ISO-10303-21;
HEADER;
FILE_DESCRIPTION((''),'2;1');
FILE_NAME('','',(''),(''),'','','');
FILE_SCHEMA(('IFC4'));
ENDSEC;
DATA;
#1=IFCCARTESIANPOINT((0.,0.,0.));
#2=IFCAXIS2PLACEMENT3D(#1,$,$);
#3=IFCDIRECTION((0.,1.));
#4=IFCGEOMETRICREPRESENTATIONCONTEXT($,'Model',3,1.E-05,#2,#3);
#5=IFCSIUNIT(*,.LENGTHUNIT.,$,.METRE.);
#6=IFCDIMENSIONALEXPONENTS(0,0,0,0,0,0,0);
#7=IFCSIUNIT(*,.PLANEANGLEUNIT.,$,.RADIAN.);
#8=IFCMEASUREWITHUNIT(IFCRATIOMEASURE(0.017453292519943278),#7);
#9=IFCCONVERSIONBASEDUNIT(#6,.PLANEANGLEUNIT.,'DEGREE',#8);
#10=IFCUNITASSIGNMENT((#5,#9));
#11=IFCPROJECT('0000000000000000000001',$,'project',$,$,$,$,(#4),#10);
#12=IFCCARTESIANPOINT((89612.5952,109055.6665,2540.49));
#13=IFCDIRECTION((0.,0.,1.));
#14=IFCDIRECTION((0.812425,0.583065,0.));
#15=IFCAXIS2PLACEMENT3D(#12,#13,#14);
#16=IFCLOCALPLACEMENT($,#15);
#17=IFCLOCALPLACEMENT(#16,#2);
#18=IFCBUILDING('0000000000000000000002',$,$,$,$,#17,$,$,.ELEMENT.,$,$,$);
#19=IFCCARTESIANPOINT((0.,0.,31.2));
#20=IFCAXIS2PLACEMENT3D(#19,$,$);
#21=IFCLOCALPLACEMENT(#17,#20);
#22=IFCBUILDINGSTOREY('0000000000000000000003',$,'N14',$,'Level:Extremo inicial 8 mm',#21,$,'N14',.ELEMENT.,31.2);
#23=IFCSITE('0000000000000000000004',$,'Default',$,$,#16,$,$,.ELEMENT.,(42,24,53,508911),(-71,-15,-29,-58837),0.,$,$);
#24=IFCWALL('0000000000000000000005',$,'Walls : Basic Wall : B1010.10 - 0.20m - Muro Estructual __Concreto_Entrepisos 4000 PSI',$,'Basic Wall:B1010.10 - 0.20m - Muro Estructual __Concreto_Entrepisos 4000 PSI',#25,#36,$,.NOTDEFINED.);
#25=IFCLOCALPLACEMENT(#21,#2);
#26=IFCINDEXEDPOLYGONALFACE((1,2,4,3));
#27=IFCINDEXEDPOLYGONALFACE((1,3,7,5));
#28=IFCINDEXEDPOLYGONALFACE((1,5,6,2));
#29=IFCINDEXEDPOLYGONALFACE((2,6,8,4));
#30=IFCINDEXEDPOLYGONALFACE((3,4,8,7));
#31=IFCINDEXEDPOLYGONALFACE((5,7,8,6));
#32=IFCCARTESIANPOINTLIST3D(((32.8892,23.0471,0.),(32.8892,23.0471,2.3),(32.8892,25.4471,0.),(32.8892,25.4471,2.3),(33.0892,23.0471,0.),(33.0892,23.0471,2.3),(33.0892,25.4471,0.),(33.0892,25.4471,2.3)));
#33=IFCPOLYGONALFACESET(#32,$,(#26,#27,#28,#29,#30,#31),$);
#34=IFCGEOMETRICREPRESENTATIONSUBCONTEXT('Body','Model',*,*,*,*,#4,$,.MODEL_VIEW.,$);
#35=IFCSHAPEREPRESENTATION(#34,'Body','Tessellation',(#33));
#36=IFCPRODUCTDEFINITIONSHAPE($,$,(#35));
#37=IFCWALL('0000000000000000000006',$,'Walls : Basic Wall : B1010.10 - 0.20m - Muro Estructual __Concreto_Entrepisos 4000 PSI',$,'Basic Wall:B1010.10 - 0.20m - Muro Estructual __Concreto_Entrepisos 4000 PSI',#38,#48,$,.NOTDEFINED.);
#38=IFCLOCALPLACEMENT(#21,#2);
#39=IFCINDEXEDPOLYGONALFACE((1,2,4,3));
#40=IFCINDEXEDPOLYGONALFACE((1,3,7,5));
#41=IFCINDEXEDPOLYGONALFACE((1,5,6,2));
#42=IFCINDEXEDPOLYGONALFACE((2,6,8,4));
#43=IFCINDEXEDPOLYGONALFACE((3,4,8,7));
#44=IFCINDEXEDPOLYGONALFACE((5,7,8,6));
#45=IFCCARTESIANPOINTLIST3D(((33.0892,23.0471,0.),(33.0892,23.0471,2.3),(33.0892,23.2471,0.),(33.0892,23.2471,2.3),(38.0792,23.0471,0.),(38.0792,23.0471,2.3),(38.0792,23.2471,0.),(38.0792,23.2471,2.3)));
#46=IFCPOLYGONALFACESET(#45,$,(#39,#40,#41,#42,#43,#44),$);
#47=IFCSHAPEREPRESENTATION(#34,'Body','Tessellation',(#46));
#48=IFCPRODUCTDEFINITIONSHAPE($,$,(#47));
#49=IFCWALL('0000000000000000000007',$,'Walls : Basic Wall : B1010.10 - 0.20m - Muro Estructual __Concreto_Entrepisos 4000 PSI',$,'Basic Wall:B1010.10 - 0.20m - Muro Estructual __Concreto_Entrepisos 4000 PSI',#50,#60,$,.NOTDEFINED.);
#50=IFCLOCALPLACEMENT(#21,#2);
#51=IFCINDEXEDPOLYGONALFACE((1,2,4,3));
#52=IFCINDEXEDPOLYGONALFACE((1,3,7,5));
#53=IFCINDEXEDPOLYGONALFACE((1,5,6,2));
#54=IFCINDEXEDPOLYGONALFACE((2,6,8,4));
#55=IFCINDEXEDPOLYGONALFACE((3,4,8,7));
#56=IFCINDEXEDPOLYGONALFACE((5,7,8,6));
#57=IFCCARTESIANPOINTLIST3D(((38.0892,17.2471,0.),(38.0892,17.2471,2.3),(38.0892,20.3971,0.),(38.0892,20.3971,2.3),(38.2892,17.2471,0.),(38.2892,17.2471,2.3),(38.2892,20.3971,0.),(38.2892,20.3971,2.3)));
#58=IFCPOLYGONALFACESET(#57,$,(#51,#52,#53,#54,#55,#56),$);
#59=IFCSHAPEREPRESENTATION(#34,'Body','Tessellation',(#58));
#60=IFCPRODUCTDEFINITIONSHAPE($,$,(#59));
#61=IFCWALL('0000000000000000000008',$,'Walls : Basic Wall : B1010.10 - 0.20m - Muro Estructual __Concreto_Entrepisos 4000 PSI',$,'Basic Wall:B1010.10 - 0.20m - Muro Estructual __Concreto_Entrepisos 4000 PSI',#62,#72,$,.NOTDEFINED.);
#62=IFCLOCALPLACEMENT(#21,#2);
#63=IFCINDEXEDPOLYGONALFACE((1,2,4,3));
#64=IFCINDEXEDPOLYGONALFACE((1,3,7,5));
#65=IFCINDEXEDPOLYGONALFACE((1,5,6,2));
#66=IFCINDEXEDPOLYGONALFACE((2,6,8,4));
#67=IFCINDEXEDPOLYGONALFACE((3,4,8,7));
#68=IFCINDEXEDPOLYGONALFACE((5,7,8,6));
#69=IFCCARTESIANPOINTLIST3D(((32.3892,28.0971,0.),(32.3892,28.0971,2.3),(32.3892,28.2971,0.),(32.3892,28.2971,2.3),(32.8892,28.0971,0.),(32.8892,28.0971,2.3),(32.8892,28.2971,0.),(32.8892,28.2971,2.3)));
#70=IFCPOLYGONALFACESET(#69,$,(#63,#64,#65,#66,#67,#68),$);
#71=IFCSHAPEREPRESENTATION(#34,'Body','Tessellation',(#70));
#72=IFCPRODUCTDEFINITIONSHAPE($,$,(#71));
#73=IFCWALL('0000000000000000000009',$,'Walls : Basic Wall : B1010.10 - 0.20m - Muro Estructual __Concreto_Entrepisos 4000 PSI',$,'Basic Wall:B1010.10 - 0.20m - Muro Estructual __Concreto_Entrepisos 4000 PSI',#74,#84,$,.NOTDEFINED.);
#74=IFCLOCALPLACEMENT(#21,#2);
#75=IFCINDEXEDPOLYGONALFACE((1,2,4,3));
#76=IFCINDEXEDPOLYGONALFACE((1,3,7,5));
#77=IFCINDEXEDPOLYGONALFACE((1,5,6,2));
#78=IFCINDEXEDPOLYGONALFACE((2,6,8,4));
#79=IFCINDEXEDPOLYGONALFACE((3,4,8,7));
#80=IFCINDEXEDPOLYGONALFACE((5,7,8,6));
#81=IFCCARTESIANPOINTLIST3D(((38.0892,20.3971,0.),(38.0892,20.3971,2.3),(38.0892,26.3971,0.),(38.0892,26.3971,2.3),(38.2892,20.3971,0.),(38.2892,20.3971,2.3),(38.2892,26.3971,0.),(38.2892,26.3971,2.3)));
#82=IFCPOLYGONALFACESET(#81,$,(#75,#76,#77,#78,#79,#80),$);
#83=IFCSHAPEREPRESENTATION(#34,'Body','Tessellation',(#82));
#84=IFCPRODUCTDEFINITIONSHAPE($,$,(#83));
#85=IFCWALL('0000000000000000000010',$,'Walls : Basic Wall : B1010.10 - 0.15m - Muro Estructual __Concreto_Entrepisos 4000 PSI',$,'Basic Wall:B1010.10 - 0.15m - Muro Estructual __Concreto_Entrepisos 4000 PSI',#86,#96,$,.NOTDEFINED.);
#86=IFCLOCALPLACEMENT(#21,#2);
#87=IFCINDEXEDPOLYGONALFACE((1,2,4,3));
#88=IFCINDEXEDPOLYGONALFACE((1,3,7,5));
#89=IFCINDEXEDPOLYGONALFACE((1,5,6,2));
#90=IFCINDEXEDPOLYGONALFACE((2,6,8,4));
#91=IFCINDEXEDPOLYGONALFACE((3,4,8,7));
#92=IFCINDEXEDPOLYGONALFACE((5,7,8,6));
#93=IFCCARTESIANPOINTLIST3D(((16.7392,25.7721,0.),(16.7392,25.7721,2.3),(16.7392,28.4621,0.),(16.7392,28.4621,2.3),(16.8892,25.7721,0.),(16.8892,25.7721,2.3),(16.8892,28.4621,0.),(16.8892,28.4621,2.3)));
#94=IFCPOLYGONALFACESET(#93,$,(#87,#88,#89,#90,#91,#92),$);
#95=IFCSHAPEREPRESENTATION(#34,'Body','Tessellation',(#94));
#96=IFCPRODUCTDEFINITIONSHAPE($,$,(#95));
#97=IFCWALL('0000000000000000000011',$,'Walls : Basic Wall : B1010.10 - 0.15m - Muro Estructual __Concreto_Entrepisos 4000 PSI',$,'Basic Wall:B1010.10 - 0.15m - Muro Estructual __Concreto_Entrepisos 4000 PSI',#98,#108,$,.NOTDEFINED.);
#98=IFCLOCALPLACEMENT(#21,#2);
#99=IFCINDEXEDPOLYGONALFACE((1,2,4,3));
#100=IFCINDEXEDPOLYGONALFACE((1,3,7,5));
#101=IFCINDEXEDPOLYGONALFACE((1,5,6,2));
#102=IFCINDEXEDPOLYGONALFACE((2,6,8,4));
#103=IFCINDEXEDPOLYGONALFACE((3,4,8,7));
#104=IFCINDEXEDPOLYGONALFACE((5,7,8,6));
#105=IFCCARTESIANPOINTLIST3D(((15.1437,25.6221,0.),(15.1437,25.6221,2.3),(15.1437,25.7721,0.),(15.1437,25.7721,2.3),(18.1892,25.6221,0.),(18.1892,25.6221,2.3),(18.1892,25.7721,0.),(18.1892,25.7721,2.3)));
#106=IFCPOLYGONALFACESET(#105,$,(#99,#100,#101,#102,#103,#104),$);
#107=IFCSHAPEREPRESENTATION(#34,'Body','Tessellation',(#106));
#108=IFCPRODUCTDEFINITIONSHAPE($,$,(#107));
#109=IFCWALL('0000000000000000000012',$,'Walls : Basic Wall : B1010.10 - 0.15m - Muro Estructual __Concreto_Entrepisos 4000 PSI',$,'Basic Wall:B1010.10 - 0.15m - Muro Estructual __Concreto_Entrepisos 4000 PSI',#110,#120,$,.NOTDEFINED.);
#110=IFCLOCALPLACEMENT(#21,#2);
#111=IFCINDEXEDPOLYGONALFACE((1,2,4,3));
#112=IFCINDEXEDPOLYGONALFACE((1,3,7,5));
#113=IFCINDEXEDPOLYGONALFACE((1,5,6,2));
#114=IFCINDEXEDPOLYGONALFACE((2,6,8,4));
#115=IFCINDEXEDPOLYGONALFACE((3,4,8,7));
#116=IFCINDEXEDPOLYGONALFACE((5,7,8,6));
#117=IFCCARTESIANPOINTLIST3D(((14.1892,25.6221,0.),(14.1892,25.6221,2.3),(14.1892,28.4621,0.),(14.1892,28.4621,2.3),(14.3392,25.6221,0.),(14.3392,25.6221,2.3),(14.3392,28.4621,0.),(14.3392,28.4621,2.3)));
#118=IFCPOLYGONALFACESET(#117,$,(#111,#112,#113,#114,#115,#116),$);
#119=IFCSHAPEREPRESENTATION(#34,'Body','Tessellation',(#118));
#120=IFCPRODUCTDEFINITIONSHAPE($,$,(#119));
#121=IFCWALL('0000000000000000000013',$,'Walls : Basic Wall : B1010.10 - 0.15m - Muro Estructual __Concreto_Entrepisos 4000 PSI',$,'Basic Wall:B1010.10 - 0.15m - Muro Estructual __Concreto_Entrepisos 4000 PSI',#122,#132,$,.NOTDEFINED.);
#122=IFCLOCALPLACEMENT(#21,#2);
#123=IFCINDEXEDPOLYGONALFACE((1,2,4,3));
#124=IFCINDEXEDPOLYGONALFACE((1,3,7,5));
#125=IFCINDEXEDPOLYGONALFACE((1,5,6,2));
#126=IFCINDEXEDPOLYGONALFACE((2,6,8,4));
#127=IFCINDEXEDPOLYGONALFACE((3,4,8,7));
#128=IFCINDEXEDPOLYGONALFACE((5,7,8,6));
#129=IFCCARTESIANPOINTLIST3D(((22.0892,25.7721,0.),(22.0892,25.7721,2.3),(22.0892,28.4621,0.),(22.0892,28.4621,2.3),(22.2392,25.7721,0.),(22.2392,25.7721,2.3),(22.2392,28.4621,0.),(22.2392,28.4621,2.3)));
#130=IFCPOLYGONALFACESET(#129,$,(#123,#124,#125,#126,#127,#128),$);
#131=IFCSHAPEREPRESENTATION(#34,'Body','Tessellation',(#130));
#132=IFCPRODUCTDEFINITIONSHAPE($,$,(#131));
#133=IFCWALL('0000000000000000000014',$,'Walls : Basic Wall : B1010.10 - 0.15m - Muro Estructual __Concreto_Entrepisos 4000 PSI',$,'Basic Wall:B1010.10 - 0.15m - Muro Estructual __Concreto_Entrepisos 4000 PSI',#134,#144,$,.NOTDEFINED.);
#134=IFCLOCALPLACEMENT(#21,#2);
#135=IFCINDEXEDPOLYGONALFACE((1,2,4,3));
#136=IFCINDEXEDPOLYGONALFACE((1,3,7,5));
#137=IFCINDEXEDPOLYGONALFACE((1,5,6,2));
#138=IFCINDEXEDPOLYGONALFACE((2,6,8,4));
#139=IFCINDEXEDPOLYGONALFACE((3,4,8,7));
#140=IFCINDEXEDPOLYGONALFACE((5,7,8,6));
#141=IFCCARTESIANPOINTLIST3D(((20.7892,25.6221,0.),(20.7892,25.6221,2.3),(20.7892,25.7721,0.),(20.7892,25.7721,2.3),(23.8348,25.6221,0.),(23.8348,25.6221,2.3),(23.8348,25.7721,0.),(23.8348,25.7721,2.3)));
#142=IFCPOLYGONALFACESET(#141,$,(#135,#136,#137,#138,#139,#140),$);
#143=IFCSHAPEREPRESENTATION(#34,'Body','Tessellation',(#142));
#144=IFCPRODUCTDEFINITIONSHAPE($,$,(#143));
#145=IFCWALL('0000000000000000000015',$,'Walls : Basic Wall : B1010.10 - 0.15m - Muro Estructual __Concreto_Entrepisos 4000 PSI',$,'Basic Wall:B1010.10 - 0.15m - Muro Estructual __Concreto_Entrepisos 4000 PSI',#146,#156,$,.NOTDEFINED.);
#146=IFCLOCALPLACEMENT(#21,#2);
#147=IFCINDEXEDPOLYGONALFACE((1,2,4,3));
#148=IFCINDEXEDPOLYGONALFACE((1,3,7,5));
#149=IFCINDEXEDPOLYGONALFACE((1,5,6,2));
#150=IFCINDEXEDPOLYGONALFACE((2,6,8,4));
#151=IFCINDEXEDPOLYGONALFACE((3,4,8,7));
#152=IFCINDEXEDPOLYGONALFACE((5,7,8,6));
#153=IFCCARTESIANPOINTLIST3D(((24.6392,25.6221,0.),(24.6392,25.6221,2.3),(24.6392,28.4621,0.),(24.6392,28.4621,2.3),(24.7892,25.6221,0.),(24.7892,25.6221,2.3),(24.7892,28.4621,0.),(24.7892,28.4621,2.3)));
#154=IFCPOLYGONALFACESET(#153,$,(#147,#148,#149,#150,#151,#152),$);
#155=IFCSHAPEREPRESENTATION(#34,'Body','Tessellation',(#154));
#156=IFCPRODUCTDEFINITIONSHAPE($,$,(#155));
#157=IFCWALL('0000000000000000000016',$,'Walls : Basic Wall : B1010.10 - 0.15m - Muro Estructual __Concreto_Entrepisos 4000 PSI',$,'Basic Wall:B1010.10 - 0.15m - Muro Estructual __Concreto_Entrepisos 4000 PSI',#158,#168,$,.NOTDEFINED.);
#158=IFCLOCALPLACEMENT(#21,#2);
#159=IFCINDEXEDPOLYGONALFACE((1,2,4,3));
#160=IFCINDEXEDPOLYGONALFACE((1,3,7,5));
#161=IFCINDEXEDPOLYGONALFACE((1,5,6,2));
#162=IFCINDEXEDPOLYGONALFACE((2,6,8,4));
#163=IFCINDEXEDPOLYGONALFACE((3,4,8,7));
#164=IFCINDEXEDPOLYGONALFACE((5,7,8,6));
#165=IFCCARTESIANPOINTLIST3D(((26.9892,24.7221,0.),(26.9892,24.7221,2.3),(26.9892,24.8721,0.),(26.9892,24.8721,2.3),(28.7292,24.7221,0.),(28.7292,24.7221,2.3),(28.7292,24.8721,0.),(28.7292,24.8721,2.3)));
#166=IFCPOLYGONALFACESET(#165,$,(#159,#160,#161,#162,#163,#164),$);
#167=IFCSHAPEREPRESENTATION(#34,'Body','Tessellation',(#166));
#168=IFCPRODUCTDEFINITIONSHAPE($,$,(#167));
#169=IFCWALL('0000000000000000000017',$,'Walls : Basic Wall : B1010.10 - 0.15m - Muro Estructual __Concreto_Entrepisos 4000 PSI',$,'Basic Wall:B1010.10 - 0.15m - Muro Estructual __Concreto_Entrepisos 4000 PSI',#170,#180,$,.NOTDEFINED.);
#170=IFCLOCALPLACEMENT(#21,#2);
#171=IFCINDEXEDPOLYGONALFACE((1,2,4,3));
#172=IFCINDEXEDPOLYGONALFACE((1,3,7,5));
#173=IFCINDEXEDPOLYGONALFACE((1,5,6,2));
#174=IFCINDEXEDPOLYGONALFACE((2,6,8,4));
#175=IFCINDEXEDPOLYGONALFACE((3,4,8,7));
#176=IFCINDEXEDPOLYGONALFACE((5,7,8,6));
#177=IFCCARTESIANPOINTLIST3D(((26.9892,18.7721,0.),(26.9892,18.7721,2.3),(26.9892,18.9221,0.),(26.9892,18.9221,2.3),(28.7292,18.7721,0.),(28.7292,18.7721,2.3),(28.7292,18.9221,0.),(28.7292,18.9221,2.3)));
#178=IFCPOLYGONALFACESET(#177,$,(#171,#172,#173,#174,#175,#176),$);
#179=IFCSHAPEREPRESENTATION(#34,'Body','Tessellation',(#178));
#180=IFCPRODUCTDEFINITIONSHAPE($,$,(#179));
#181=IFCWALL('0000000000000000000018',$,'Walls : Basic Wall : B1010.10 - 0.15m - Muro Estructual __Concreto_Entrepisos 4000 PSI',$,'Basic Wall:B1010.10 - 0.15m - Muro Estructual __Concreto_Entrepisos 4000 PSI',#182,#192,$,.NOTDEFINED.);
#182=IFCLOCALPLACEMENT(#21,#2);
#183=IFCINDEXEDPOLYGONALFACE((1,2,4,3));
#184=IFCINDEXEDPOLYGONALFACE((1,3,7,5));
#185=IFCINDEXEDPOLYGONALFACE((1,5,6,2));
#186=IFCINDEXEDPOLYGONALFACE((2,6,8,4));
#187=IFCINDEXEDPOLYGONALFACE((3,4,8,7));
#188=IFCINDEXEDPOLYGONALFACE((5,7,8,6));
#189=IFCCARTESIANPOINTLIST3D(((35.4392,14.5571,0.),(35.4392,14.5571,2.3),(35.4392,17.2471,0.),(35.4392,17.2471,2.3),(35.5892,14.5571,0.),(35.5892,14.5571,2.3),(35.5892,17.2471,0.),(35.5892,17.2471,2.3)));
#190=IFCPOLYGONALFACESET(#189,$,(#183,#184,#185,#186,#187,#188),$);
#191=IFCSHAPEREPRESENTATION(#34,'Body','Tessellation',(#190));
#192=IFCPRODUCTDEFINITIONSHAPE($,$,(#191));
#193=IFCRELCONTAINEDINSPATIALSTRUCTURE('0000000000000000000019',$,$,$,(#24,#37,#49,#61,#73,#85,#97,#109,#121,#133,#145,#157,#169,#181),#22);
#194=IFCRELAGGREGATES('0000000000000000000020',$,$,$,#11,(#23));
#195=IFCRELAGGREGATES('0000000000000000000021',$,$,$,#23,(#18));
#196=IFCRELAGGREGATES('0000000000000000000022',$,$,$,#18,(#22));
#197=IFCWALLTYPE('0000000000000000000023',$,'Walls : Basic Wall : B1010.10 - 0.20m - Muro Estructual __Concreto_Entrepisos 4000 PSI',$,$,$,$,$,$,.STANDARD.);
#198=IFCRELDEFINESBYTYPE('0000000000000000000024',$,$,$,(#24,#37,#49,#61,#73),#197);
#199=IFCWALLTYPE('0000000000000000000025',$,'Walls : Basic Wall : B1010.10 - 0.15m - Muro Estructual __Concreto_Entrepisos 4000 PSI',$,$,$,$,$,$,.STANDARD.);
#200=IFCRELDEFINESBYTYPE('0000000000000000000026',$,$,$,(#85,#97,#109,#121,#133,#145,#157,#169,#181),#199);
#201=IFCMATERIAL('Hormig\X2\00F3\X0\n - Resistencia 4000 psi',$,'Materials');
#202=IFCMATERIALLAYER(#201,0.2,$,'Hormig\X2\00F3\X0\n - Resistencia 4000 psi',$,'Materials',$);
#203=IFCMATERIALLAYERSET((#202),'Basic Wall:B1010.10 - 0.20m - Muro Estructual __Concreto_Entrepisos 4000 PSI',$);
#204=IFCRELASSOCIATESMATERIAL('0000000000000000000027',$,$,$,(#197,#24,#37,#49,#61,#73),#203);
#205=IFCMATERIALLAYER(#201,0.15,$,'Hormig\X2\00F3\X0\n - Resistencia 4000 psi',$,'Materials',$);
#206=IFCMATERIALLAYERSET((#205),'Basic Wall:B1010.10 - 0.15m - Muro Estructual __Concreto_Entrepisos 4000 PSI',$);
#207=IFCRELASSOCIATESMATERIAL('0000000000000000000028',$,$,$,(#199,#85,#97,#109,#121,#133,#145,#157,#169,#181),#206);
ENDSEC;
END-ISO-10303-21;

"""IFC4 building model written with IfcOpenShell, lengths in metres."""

from ifc_helpers import new_model, entity, si_unit, converted_unit, direction, frame, frame_2d, origin, place, context, subcontext, project, spatial, rectangle, extrude, material, layer, layer_set, layer_usage, type_object, element, save


model = new_model("IFC4")

# Units and contexts
model_context = context("Model", 3, precision=1e-05, world=origin(), true_north=direction((0.0, 1.0)))
body_context = subcontext(model_context, "Body", "Model", "MODEL_VIEW")
ifc_project = project(units=[si_unit("LENGTHUNIT", "METRE"), converted_unit("PLANEANGLEUNIT", "DEGREE", entity("IfcRatioMeasure", 0.017453292519943278), si_unit("PLANEANGLEUNIT", "RADIAN"), dimensions=[0, 0, 0, 0, 0, 0, 0])], contexts=[model_context])

# Site, building, storey
site_placement = place(None, frame((89612.5952, 109055.6665, 2540.49), z_axis=(0.0, 0.0, 1.0), x_axis=(0.812425, 0.583065, 0.0)))
site = spatial("IfcSite", under=ifc_project, at=site_placement, Name="Default", CompositionType="ELEMENT", RefLatitude=(42, 24, 53, 508911), RefLongitude=(-71, -15, -29, -58837), RefElevation=0.0)
building_placement = place(site_placement, origin())
building = spatial("IfcBuilding", under=site, at=building_placement, CompositionType="ELEMENT")
storey_placement = place(building_placement, frame((0.0, 0.0, 31.2)))
storey = spatial("IfcBuildingStorey", under=building, at=storey_placement, Name="N14", ObjectType="Level:Extremo inicial 8 mm", LongName="N14", CompositionType="ELEMENT", Elevation=31.2)

# Walls
ifc_material = material(Name="Hormigón - Resistencia 4000 psi", Category="Materials")
ifc_layer_1 = layer(ifc_material, 0.2, Name="Hormigón - Resistencia 4000 psi", Category="Materials")
ifc_layer_set_1 = layer_set([ifc_layer_1], Name="Basic Wall:B1010.10 - 0.20m - Muro Estructual __Concreto_Entrepisos 4000 PSI")
wall_type_1 = type_object("IfcWallType", Name="Walls : Basic Wall : B1010.10 - 0.20m - Muro Estructual __Concreto_Entrepisos 4000 PSI", PredefinedType="STANDARD", material=ifc_layer_set_1)
ifc_layer_usage_1 = layer_usage(ifc_layer_set_1, "AXIS2", "POSITIVE", -0.1)
wall_1_placement = place(storey_placement, frame((32.9892, 25.4471, 0.0), z_axis=(0.0, 0.0, 1.0), x_axis=(0.0, -1.0, 0.0)))
element("IfcWall", 1, at=wall_1_placement, inside=storey, type_object=wall_type_1, material=ifc_layer_usage_1, Name="Walls : Basic Wall : B1010.10 - 0.20m - Muro Estructual __Concreto_Entrepisos 4000 PSI", ObjectType="Basic Wall:B1010.10 - 0.20m - Muro Estructual __Concreto_Entrepisos 4000 PSI", PredefinedType="NOTDEFINED", context=body_context, shape_type="SweptSolid", body=[
    extrude(rectangle(XDim=2.4, YDim=0.2, at=frame_2d((1.2, 0.0), x_axis=(-1.0, 0.0))), origin(), (0.0, 0.0, 1.0), 2.3),
])
ifc_layer_usage_2 = layer_usage(ifc_layer_set_1, "AXIS2", "POSITIVE", -0.1)
wall_2_placement = place(storey_placement, frame((33.0892, 23.1471, 0.0)))
element("IfcWall", 2, at=wall_2_placement, inside=storey, type_object=wall_type_1, material=ifc_layer_usage_2, Name="Walls : Basic Wall : B1010.10 - 0.20m - Muro Estructual __Concreto_Entrepisos 4000 PSI", ObjectType="Basic Wall:B1010.10 - 0.20m - Muro Estructual __Concreto_Entrepisos 4000 PSI", PredefinedType="NOTDEFINED", context=body_context, shape_type="SweptSolid", body=[
    extrude(rectangle(XDim=4.99, YDim=0.2, at=frame_2d((2.495, 0.0), x_axis=(-1.0, 0.0))), origin(), (0.0, 0.0, 1.0), 2.3),
])
ifc_layer_usage_3 = layer_usage(ifc_layer_set_1, "AXIS2", "POSITIVE", -0.1)
wall_3_placement = place(storey_placement, frame((38.1892, 17.2471, 0.0), z_axis=(0.0, 0.0, 1.0), x_axis=(0.0, 1.0, 0.0)))
element("IfcWall", 3, at=wall_3_placement, inside=storey, type_object=wall_type_1, material=ifc_layer_usage_3, Name="Walls : Basic Wall : B1010.10 - 0.20m - Muro Estructual __Concreto_Entrepisos 4000 PSI", ObjectType="Basic Wall:B1010.10 - 0.20m - Muro Estructual __Concreto_Entrepisos 4000 PSI", PredefinedType="NOTDEFINED", context=body_context, shape_type="SweptSolid", body=[
    extrude(rectangle(XDim=3.15, YDim=0.2, at=frame_2d((1.575, 0.0), x_axis=(-1.0, 0.0))), origin(), (0.0, 0.0, 1.0), 2.3),
])
ifc_layer_usage_4 = layer_usage(ifc_layer_set_1, "AXIS2", "POSITIVE", -0.1)
wall_4_placement = place(storey_placement, frame((32.3892, 28.1971, 0.0)))
element("IfcWall", 4, at=wall_4_placement, inside=storey, type_object=wall_type_1, material=ifc_layer_usage_4, Name="Walls : Basic Wall : B1010.10 - 0.20m - Muro Estructual __Concreto_Entrepisos 4000 PSI", ObjectType="Basic Wall:B1010.10 - 0.20m - Muro Estructual __Concreto_Entrepisos 4000 PSI", PredefinedType="NOTDEFINED", context=body_context, shape_type="SweptSolid", body=[
    extrude(rectangle(XDim=0.5, YDim=0.2, at=frame_2d((0.25, 0.0), x_axis=(-1.0, 0.0))), origin(), (0.0, 0.0, 1.0), 2.3),
])
ifc_layer_usage_5 = layer_usage(ifc_layer_set_1, "AXIS2", "POSITIVE", -0.1)
wall_5_placement = place(storey_placement, frame((38.1892, 20.3971, 0.0), z_axis=(0.0, 0.0, 1.0), x_axis=(0.0, 1.0, 0.0)))
element("IfcWall", 5, at=wall_5_placement, inside=storey, type_object=wall_type_1, material=ifc_layer_usage_5, Name="Walls : Basic Wall : B1010.10 - 0.20m - Muro Estructual __Concreto_Entrepisos 4000 PSI", ObjectType="Basic Wall:B1010.10 - 0.20m - Muro Estructual __Concreto_Entrepisos 4000 PSI", PredefinedType="NOTDEFINED", context=body_context, shape_type="SweptSolid", body=[
    extrude(rectangle(XDim=6.0, YDim=0.2, at=frame_2d((3.0, 0.0), x_axis=(-1.0, 0.0))), origin(), (0.0, 0.0, 1.0), 2.3),
])
ifc_layer_2 = layer(ifc_material, 0.15, Name="Hormigón - Resistencia 4000 psi", Category="Materials")
ifc_layer_set_2 = layer_set([ifc_layer_2], Name="Basic Wall:B1010.10 - 0.15m - Muro Estructual __Concreto_Entrepisos 4000 PSI")
ifc_layer_usage_6 = layer_usage(ifc_layer_set_2, "AXIS2", "POSITIVE", -0.075)
wall_type_2 = type_object("IfcWallType", Name="Walls : Basic Wall : B1010.10 - 0.15m - Muro Estructual __Concreto_Entrepisos 4000 PSI", PredefinedType="STANDARD", material=ifc_layer_set_2)
wall_6_placement = place(storey_placement, frame((16.8142, 28.4621, 0.0), z_axis=(0.0, 0.0, 1.0), x_axis=(0.0, -1.0, 0.0)))
element("IfcWall", 6, at=wall_6_placement, inside=storey, type_object=wall_type_2, material=ifc_layer_usage_6, Name="Walls : Basic Wall : B1010.10 - 0.15m - Muro Estructual __Concreto_Entrepisos 4000 PSI", ObjectType="Basic Wall:B1010.10 - 0.15m - Muro Estructual __Concreto_Entrepisos 4000 PSI", PredefinedType="NOTDEFINED", context=body_context, shape_type="SweptSolid", body=[
    extrude(rectangle(XDim=2.69, YDim=0.15, at=frame_2d((1.345, 0.0), x_axis=(-1.0, 0.0))), origin(), (0.0, 0.0, 1.0), 2.3),
])
ifc_layer_usage_7 = layer_usage(ifc_layer_set_2, "AXIS2", "POSITIVE", -0.075)
wall_7_placement = place(storey_placement, frame((18.1892, 25.6971, 0.0), z_axis=(0.0, 0.0, 1.0), x_axis=(-1.0, 0.0, 0.0)))
element("IfcWall", 7, at=wall_7_placement, inside=storey, type_object=wall_type_2, material=ifc_layer_usage_7, Name="Walls : Basic Wall : B1010.10 - 0.15m - Muro Estructual __Concreto_Entrepisos 4000 PSI", ObjectType="Basic Wall:B1010.10 - 0.15m - Muro Estructual __Concreto_Entrepisos 4000 PSI", PredefinedType="NOTDEFINED", context=body_context, shape_type="SweptSolid", body=[
    extrude(rectangle(XDim=3.0455, YDim=0.15, at=frame_2d((1.5228, 0.0), x_axis=(-1.0, 0.0))), origin(), (0.0, 0.0, 1.0), 2.3),
])
ifc_layer_usage_8 = layer_usage(ifc_layer_set_2, "AXIS2", "POSITIVE", -0.075)
wall_8_placement = place(storey_placement, frame((14.2642, 28.4621, 0.0), z_axis=(0.0, 0.0, 1.0), x_axis=(0.0, -1.0, 0.0)))
element("IfcWall", 8, at=wall_8_placement, inside=storey, type_object=wall_type_2, material=ifc_layer_usage_8, Name="Walls : Basic Wall : B1010.10 - 0.15m - Muro Estructual __Concreto_Entrepisos 4000 PSI", ObjectType="Basic Wall:B1010.10 - 0.15m - Muro Estructual __Concreto_Entrepisos 4000 PSI", PredefinedType="NOTDEFINED", context=body_context, shape_type="SweptSolid", body=[
    extrude(rectangle(XDim=2.84, YDim=0.15, at=frame_2d((1.42, 0.0), x_axis=(-1.0, 0.0))), origin(), (0.0, 0.0, 1.0), 2.3),
])
ifc_layer_usage_9 = layer_usage(ifc_layer_set_2, "AXIS2", "NEGATIVE", 0.075)
wall_9_placement = place(storey_placement, frame((22.1642, 28.4621, 0.0), z_axis=(0.0, 0.0, 1.0), x_axis=(0.0, -1.0, 0.0)))
element("IfcWall", 9, at=wall_9_placement, inside=storey, type_object=wall_type_2, material=ifc_layer_usage_9, Name="Walls : Basic Wall : B1010.10 - 0.15m - Muro Estructual __Concreto_Entrepisos 4000 PSI", ObjectType="Basic Wall:B1010.10 - 0.15m - Muro Estructual __Concreto_Entrepisos 4000 PSI", PredefinedType="NOTDEFINED", context=body_context, shape_type="SweptSolid", body=[
    extrude(rectangle(XDim=2.69, YDim=0.15, at=frame_2d((1.345, 0.0), x_axis=(-1.0, 0.0))), origin(), (0.0, 0.0, 1.0), 2.3),
])
ifc_layer_usage_10 = layer_usage(ifc_layer_set_2, "AXIS2", "NEGATIVE", 0.075)
wall_10_placement = place(storey_placement, frame((20.7892, 25.6971, 0.0)))
element("IfcWall", 10, at=wall_10_placement, inside=storey, type_object=wall_type_2, material=ifc_layer_usage_10, Name="Walls : Basic Wall : B1010.10 - 0.15m - Muro Estructual __Concreto_Entrepisos 4000 PSI", ObjectType="Basic Wall:B1010.10 - 0.15m - Muro Estructual __Concreto_Entrepisos 4000 PSI", PredefinedType="NOTDEFINED", context=body_context, shape_type="SweptSolid", body=[
    extrude(rectangle(XDim=3.0455, YDim=0.15, at=frame_2d((1.5228, 0.0), x_axis=(-1.0, 0.0))), origin(), (0.0, 0.0, 1.0), 2.3),
])
ifc_layer_usage_11 = layer_usage(ifc_layer_set_2, "AXIS2", "NEGATIVE", 0.075)
wall_11_placement = place(storey_placement, frame((24.7142, 28.4621, 0.0), z_axis=(0.0, 0.0, 1.0), x_axis=(0.0, -1.0, 0.0)))
element("IfcWall", 11, at=wall_11_placement, inside=storey, type_object=wall_type_2, material=ifc_layer_usage_11, Name="Walls : Basic Wall : B1010.10 - 0.15m - Muro Estructual __Concreto_Entrepisos 4000 PSI", ObjectType="Basic Wall:B1010.10 - 0.15m - Muro Estructual __Concreto_Entrepisos 4000 PSI", PredefinedType="NOTDEFINED", context=body_context, shape_type="SweptSolid", body=[
    extrude(rectangle(XDim=2.84, YDim=0.15, at=frame_2d((1.42, 0.0), x_axis=(-1.0, 0.0))), origin(), (0.0, 0.0, 1.0), 2.3),
])
ifc_layer_usage_12 = layer_usage(ifc_layer_set_2, "AXIS2", "NEGATIVE", 0.075)
wall_12_placement = place(storey_placement, frame((26.9892, 24.7971, 0.0)))
element("IfcWall", 12, at=wall_12_placement, inside=storey, type_object=wall_type_2, material=ifc_layer_usage_12, Name="Walls : Basic Wall : B1010.10 - 0.15m - Muro Estructual __Concreto_Entrepisos 4000 PSI", ObjectType="Basic Wall:B1010.10 - 0.15m - Muro Estructual __Concreto_Entrepisos 4000 PSI", PredefinedType="NOTDEFINED", context=body_context, shape_type="SweptSolid", body=[
    extrude(rectangle(XDim=1.74, YDim=0.15, at=frame_2d((0.87, 0.0), x_axis=(-1.0, 0.0))), origin(), (0.0, 0.0, 1.0), 2.3),
])
ifc_layer_usage_13 = layer_usage(ifc_layer_set_2, "AXIS2", "POSITIVE", -0.075)
wall_13_placement = place(storey_placement, frame((26.9892, 18.8471, 0.0)))
element("IfcWall", 13, at=wall_13_placement, inside=storey, type_object=wall_type_2, material=ifc_layer_usage_13, Name="Walls : Basic Wall : B1010.10 - 0.15m - Muro Estructual __Concreto_Entrepisos 4000 PSI", ObjectType="Basic Wall:B1010.10 - 0.15m - Muro Estructual __Concreto_Entrepisos 4000 PSI", PredefinedType="NOTDEFINED", context=body_context, shape_type="SweptSolid", body=[
    extrude(rectangle(XDim=1.74, YDim=0.15, at=frame_2d((0.87, 0.0), x_axis=(-1.0, 0.0))), origin(), (0.0, 0.0, 1.0), 2.3),
])
ifc_layer_usage_14 = layer_usage(ifc_layer_set_2, "AXIS2", "NEGATIVE", 0.075)
wall_14_placement = place(storey_placement, frame((35.5142, 14.5571, 0.0), z_axis=(0.0, 0.0, 1.0), x_axis=(0.0, 1.0, 0.0)))
element("IfcWall", 14, at=wall_14_placement, inside=storey, type_object=wall_type_2, material=ifc_layer_usage_14, Name="Walls : Basic Wall : B1010.10 - 0.15m - Muro Estructual __Concreto_Entrepisos 4000 PSI", ObjectType="Basic Wall:B1010.10 - 0.15m - Muro Estructual __Concreto_Entrepisos 4000 PSI", PredefinedType="NOTDEFINED", context=body_context, shape_type="SweptSolid", body=[
    extrude(rectangle(XDim=2.69, YDim=0.15, at=frame_2d((1.345, 0.0), x_axis=(-1.0, 0.0))), origin(), (0.0, 0.0, 1.0), 2.3),
])

save(model, "model.ifc")
